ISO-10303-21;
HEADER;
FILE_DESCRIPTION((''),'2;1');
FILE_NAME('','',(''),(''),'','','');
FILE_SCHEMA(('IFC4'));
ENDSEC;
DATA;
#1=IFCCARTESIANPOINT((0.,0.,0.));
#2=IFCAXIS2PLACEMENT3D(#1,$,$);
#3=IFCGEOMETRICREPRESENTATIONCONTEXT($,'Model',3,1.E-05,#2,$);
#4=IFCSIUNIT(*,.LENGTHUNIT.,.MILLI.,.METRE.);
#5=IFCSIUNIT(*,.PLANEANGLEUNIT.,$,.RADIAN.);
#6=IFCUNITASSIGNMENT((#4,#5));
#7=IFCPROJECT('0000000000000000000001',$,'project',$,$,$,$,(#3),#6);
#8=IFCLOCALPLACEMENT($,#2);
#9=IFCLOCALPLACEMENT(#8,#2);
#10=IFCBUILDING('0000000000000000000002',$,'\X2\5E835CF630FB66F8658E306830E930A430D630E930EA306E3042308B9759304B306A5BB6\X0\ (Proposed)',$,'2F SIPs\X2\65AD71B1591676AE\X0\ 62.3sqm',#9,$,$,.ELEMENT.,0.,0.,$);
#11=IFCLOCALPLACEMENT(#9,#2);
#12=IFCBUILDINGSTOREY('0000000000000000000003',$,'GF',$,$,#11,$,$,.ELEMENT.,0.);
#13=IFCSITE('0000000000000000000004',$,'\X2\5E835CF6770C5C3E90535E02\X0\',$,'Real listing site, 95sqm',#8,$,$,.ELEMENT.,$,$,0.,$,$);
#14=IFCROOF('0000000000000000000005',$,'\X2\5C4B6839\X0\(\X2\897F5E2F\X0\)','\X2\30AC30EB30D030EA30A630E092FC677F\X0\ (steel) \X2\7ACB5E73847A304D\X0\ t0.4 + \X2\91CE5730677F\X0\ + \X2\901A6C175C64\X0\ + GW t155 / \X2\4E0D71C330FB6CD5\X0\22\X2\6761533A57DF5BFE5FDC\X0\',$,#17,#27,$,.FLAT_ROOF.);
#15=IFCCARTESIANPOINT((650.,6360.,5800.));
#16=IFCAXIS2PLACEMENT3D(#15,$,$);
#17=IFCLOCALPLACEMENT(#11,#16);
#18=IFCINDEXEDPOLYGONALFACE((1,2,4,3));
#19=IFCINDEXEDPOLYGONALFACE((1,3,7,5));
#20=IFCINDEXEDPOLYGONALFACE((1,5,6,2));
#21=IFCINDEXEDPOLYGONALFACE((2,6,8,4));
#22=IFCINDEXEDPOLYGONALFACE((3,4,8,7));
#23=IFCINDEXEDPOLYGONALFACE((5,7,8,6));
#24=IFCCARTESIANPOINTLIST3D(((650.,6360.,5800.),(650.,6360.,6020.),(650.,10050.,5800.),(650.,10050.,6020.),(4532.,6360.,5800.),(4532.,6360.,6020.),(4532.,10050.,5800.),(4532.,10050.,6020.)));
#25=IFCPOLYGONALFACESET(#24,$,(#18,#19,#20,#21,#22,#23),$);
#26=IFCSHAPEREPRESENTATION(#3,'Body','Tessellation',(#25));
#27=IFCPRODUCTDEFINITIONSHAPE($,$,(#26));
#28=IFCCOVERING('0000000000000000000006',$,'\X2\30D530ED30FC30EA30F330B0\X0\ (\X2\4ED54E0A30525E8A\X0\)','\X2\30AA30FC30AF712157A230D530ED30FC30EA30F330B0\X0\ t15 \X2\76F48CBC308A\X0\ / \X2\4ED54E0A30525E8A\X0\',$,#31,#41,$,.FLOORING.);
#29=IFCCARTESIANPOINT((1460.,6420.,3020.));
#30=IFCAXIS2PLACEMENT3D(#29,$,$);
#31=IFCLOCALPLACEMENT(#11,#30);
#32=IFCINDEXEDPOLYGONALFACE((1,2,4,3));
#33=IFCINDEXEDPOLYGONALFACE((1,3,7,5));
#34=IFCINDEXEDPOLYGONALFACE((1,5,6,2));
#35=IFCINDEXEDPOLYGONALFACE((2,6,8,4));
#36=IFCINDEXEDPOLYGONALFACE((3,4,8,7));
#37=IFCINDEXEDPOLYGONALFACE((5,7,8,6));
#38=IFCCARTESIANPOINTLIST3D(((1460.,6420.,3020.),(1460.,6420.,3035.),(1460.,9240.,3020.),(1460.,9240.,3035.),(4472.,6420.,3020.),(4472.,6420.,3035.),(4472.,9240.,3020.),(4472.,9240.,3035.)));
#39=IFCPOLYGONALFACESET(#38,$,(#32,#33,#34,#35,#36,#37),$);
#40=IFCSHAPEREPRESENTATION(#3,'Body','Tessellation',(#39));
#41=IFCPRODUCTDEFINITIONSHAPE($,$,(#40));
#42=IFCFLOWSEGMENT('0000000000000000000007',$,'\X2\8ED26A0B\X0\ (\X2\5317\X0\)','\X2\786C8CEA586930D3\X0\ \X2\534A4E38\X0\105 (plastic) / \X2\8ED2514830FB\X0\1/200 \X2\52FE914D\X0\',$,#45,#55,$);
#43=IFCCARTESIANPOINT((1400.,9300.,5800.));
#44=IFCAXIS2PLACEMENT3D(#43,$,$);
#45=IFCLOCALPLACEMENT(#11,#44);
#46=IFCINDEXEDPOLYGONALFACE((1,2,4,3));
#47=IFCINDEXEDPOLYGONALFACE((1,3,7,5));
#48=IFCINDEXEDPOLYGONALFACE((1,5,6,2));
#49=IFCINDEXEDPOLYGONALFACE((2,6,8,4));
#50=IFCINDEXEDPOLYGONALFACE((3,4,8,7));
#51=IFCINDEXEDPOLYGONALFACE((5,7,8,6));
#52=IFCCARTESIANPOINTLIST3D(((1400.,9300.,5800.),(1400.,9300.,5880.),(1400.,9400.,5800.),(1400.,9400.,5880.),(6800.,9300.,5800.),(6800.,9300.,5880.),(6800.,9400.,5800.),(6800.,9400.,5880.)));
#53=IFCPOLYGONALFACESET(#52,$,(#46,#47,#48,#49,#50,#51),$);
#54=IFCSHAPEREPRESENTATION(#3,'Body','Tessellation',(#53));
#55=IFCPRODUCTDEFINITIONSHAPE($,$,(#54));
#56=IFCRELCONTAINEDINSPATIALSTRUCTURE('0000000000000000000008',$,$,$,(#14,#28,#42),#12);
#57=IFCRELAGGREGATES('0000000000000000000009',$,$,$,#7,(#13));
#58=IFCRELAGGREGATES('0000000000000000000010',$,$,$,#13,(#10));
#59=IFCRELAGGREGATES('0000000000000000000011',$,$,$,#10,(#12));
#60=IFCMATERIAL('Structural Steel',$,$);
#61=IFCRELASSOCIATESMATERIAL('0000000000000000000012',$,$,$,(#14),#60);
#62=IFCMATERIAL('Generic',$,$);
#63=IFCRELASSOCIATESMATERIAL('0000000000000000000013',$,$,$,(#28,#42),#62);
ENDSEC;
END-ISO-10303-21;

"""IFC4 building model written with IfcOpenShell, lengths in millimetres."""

from ifc_helpers import new_model, si_unit, frame, frame_2d, origin, place, context, project, spatial, rectangle, extrude, material, element, save


model = new_model("IFC4")

# Units and contexts
model_context = context("Model", 3, precision=1e-05, world=origin())
ifc_project = project(units=[si_unit("LENGTHUNIT", "METRE", prefix="MILLI"), si_unit("PLANEANGLEUNIT", "RADIAN")], contexts=[model_context])

# Site, building, storey
site_placement = place(None, origin())
site = spatial("IfcSite", under=ifc_project, at=site_placement, Name="広島県尾道市", ObjectType="Real listing site, 95sqm", CompositionType="ELEMENT", RefElevation=0.0)
building_placement = place(site_placement, origin())
building = spatial("IfcBuilding", under=site, at=building_placement, Name="広島・書斎とライブラリのある静かな家 (Proposed)", ObjectType="2F SIPs断熱外皮 62.3sqm", CompositionType="ELEMENT", ElevationOfRefHeight=0.0, ElevationOfTerrain=0.0)
storey_placement = place(building_placement, origin())
storey = spatial("IfcBuildingStorey", under=building, at=storey_placement, Name="GF", CompositionType="ELEMENT", Elevation=0.0)

# Roof
ifc_material_1 = material(Name="Structural Steel")
for number, where, name in (
    (1, (650.0, 6360.0, 5800.0), "屋根(西帯)"),
):
    element("IfcRoof", number, at=place(storey_placement, frame(where)), inside=storey, material=ifc_material_1, Name=name, Description="ガルバリウム鋼板 (steel) 立平葺き t0.4 + 野地板 + 通気層 + GW t155 / 不燃・法22条区域対応", PredefinedType="FLAT_ROOF", context=model_context, shape_type="SweptSolid", body=[
        extrude(rectangle(XDim=3882.0, YDim=3690.0, at=frame_2d((1941.0, 1845.0))), frame((650.0, 6360.0, 5800.0)), (0.0, 0.0, 1.0), 220.0),
    ])

# Covering
ifc_material_2 = material(Name="Generic")
covering_placement = place(storey_placement, frame((1460.0, 6420.0, 3020.0)))
element("IfcCovering", 2, at=covering_placement, inside=storey, material=ifc_material_2, Name="フローリング (仕上げ床)", Description="オーク無垢フローリング t15 直貼り / 仕上げ床", PredefinedType="FLOORING", context=model_context, shape_type="SweptSolid", body=[
    extrude(rectangle(XDim=3012.0, YDim=2820.0, at=frame_2d((1506.0, 1410.0))), frame((1460.0, 6420.0, 3020.0)), (0.0, 0.0, 1.0), 15.0),
])

# Flow segment
flow_segment_placement = place(storey_placement, frame((1400.0, 9300.0, 5800.0)))
element("IfcFlowSegment", 3, at=flow_segment_placement, inside=storey, material=ifc_material_2, Name="軒樋 (北)", Description="硬質塩ビ 半丸105 (plastic) / 軒先・1/200 勾配", context=model_context, shape_type="SweptSolid", body=[
    extrude(rectangle(XDim=5400.0, YDim=100.0, at=frame_2d((2700.0, 50.0))), frame((1400.0, 9300.0, 5800.0)), (0.0, 0.0, 1.0), 80.0),
])

save(model, "model.ifc")
